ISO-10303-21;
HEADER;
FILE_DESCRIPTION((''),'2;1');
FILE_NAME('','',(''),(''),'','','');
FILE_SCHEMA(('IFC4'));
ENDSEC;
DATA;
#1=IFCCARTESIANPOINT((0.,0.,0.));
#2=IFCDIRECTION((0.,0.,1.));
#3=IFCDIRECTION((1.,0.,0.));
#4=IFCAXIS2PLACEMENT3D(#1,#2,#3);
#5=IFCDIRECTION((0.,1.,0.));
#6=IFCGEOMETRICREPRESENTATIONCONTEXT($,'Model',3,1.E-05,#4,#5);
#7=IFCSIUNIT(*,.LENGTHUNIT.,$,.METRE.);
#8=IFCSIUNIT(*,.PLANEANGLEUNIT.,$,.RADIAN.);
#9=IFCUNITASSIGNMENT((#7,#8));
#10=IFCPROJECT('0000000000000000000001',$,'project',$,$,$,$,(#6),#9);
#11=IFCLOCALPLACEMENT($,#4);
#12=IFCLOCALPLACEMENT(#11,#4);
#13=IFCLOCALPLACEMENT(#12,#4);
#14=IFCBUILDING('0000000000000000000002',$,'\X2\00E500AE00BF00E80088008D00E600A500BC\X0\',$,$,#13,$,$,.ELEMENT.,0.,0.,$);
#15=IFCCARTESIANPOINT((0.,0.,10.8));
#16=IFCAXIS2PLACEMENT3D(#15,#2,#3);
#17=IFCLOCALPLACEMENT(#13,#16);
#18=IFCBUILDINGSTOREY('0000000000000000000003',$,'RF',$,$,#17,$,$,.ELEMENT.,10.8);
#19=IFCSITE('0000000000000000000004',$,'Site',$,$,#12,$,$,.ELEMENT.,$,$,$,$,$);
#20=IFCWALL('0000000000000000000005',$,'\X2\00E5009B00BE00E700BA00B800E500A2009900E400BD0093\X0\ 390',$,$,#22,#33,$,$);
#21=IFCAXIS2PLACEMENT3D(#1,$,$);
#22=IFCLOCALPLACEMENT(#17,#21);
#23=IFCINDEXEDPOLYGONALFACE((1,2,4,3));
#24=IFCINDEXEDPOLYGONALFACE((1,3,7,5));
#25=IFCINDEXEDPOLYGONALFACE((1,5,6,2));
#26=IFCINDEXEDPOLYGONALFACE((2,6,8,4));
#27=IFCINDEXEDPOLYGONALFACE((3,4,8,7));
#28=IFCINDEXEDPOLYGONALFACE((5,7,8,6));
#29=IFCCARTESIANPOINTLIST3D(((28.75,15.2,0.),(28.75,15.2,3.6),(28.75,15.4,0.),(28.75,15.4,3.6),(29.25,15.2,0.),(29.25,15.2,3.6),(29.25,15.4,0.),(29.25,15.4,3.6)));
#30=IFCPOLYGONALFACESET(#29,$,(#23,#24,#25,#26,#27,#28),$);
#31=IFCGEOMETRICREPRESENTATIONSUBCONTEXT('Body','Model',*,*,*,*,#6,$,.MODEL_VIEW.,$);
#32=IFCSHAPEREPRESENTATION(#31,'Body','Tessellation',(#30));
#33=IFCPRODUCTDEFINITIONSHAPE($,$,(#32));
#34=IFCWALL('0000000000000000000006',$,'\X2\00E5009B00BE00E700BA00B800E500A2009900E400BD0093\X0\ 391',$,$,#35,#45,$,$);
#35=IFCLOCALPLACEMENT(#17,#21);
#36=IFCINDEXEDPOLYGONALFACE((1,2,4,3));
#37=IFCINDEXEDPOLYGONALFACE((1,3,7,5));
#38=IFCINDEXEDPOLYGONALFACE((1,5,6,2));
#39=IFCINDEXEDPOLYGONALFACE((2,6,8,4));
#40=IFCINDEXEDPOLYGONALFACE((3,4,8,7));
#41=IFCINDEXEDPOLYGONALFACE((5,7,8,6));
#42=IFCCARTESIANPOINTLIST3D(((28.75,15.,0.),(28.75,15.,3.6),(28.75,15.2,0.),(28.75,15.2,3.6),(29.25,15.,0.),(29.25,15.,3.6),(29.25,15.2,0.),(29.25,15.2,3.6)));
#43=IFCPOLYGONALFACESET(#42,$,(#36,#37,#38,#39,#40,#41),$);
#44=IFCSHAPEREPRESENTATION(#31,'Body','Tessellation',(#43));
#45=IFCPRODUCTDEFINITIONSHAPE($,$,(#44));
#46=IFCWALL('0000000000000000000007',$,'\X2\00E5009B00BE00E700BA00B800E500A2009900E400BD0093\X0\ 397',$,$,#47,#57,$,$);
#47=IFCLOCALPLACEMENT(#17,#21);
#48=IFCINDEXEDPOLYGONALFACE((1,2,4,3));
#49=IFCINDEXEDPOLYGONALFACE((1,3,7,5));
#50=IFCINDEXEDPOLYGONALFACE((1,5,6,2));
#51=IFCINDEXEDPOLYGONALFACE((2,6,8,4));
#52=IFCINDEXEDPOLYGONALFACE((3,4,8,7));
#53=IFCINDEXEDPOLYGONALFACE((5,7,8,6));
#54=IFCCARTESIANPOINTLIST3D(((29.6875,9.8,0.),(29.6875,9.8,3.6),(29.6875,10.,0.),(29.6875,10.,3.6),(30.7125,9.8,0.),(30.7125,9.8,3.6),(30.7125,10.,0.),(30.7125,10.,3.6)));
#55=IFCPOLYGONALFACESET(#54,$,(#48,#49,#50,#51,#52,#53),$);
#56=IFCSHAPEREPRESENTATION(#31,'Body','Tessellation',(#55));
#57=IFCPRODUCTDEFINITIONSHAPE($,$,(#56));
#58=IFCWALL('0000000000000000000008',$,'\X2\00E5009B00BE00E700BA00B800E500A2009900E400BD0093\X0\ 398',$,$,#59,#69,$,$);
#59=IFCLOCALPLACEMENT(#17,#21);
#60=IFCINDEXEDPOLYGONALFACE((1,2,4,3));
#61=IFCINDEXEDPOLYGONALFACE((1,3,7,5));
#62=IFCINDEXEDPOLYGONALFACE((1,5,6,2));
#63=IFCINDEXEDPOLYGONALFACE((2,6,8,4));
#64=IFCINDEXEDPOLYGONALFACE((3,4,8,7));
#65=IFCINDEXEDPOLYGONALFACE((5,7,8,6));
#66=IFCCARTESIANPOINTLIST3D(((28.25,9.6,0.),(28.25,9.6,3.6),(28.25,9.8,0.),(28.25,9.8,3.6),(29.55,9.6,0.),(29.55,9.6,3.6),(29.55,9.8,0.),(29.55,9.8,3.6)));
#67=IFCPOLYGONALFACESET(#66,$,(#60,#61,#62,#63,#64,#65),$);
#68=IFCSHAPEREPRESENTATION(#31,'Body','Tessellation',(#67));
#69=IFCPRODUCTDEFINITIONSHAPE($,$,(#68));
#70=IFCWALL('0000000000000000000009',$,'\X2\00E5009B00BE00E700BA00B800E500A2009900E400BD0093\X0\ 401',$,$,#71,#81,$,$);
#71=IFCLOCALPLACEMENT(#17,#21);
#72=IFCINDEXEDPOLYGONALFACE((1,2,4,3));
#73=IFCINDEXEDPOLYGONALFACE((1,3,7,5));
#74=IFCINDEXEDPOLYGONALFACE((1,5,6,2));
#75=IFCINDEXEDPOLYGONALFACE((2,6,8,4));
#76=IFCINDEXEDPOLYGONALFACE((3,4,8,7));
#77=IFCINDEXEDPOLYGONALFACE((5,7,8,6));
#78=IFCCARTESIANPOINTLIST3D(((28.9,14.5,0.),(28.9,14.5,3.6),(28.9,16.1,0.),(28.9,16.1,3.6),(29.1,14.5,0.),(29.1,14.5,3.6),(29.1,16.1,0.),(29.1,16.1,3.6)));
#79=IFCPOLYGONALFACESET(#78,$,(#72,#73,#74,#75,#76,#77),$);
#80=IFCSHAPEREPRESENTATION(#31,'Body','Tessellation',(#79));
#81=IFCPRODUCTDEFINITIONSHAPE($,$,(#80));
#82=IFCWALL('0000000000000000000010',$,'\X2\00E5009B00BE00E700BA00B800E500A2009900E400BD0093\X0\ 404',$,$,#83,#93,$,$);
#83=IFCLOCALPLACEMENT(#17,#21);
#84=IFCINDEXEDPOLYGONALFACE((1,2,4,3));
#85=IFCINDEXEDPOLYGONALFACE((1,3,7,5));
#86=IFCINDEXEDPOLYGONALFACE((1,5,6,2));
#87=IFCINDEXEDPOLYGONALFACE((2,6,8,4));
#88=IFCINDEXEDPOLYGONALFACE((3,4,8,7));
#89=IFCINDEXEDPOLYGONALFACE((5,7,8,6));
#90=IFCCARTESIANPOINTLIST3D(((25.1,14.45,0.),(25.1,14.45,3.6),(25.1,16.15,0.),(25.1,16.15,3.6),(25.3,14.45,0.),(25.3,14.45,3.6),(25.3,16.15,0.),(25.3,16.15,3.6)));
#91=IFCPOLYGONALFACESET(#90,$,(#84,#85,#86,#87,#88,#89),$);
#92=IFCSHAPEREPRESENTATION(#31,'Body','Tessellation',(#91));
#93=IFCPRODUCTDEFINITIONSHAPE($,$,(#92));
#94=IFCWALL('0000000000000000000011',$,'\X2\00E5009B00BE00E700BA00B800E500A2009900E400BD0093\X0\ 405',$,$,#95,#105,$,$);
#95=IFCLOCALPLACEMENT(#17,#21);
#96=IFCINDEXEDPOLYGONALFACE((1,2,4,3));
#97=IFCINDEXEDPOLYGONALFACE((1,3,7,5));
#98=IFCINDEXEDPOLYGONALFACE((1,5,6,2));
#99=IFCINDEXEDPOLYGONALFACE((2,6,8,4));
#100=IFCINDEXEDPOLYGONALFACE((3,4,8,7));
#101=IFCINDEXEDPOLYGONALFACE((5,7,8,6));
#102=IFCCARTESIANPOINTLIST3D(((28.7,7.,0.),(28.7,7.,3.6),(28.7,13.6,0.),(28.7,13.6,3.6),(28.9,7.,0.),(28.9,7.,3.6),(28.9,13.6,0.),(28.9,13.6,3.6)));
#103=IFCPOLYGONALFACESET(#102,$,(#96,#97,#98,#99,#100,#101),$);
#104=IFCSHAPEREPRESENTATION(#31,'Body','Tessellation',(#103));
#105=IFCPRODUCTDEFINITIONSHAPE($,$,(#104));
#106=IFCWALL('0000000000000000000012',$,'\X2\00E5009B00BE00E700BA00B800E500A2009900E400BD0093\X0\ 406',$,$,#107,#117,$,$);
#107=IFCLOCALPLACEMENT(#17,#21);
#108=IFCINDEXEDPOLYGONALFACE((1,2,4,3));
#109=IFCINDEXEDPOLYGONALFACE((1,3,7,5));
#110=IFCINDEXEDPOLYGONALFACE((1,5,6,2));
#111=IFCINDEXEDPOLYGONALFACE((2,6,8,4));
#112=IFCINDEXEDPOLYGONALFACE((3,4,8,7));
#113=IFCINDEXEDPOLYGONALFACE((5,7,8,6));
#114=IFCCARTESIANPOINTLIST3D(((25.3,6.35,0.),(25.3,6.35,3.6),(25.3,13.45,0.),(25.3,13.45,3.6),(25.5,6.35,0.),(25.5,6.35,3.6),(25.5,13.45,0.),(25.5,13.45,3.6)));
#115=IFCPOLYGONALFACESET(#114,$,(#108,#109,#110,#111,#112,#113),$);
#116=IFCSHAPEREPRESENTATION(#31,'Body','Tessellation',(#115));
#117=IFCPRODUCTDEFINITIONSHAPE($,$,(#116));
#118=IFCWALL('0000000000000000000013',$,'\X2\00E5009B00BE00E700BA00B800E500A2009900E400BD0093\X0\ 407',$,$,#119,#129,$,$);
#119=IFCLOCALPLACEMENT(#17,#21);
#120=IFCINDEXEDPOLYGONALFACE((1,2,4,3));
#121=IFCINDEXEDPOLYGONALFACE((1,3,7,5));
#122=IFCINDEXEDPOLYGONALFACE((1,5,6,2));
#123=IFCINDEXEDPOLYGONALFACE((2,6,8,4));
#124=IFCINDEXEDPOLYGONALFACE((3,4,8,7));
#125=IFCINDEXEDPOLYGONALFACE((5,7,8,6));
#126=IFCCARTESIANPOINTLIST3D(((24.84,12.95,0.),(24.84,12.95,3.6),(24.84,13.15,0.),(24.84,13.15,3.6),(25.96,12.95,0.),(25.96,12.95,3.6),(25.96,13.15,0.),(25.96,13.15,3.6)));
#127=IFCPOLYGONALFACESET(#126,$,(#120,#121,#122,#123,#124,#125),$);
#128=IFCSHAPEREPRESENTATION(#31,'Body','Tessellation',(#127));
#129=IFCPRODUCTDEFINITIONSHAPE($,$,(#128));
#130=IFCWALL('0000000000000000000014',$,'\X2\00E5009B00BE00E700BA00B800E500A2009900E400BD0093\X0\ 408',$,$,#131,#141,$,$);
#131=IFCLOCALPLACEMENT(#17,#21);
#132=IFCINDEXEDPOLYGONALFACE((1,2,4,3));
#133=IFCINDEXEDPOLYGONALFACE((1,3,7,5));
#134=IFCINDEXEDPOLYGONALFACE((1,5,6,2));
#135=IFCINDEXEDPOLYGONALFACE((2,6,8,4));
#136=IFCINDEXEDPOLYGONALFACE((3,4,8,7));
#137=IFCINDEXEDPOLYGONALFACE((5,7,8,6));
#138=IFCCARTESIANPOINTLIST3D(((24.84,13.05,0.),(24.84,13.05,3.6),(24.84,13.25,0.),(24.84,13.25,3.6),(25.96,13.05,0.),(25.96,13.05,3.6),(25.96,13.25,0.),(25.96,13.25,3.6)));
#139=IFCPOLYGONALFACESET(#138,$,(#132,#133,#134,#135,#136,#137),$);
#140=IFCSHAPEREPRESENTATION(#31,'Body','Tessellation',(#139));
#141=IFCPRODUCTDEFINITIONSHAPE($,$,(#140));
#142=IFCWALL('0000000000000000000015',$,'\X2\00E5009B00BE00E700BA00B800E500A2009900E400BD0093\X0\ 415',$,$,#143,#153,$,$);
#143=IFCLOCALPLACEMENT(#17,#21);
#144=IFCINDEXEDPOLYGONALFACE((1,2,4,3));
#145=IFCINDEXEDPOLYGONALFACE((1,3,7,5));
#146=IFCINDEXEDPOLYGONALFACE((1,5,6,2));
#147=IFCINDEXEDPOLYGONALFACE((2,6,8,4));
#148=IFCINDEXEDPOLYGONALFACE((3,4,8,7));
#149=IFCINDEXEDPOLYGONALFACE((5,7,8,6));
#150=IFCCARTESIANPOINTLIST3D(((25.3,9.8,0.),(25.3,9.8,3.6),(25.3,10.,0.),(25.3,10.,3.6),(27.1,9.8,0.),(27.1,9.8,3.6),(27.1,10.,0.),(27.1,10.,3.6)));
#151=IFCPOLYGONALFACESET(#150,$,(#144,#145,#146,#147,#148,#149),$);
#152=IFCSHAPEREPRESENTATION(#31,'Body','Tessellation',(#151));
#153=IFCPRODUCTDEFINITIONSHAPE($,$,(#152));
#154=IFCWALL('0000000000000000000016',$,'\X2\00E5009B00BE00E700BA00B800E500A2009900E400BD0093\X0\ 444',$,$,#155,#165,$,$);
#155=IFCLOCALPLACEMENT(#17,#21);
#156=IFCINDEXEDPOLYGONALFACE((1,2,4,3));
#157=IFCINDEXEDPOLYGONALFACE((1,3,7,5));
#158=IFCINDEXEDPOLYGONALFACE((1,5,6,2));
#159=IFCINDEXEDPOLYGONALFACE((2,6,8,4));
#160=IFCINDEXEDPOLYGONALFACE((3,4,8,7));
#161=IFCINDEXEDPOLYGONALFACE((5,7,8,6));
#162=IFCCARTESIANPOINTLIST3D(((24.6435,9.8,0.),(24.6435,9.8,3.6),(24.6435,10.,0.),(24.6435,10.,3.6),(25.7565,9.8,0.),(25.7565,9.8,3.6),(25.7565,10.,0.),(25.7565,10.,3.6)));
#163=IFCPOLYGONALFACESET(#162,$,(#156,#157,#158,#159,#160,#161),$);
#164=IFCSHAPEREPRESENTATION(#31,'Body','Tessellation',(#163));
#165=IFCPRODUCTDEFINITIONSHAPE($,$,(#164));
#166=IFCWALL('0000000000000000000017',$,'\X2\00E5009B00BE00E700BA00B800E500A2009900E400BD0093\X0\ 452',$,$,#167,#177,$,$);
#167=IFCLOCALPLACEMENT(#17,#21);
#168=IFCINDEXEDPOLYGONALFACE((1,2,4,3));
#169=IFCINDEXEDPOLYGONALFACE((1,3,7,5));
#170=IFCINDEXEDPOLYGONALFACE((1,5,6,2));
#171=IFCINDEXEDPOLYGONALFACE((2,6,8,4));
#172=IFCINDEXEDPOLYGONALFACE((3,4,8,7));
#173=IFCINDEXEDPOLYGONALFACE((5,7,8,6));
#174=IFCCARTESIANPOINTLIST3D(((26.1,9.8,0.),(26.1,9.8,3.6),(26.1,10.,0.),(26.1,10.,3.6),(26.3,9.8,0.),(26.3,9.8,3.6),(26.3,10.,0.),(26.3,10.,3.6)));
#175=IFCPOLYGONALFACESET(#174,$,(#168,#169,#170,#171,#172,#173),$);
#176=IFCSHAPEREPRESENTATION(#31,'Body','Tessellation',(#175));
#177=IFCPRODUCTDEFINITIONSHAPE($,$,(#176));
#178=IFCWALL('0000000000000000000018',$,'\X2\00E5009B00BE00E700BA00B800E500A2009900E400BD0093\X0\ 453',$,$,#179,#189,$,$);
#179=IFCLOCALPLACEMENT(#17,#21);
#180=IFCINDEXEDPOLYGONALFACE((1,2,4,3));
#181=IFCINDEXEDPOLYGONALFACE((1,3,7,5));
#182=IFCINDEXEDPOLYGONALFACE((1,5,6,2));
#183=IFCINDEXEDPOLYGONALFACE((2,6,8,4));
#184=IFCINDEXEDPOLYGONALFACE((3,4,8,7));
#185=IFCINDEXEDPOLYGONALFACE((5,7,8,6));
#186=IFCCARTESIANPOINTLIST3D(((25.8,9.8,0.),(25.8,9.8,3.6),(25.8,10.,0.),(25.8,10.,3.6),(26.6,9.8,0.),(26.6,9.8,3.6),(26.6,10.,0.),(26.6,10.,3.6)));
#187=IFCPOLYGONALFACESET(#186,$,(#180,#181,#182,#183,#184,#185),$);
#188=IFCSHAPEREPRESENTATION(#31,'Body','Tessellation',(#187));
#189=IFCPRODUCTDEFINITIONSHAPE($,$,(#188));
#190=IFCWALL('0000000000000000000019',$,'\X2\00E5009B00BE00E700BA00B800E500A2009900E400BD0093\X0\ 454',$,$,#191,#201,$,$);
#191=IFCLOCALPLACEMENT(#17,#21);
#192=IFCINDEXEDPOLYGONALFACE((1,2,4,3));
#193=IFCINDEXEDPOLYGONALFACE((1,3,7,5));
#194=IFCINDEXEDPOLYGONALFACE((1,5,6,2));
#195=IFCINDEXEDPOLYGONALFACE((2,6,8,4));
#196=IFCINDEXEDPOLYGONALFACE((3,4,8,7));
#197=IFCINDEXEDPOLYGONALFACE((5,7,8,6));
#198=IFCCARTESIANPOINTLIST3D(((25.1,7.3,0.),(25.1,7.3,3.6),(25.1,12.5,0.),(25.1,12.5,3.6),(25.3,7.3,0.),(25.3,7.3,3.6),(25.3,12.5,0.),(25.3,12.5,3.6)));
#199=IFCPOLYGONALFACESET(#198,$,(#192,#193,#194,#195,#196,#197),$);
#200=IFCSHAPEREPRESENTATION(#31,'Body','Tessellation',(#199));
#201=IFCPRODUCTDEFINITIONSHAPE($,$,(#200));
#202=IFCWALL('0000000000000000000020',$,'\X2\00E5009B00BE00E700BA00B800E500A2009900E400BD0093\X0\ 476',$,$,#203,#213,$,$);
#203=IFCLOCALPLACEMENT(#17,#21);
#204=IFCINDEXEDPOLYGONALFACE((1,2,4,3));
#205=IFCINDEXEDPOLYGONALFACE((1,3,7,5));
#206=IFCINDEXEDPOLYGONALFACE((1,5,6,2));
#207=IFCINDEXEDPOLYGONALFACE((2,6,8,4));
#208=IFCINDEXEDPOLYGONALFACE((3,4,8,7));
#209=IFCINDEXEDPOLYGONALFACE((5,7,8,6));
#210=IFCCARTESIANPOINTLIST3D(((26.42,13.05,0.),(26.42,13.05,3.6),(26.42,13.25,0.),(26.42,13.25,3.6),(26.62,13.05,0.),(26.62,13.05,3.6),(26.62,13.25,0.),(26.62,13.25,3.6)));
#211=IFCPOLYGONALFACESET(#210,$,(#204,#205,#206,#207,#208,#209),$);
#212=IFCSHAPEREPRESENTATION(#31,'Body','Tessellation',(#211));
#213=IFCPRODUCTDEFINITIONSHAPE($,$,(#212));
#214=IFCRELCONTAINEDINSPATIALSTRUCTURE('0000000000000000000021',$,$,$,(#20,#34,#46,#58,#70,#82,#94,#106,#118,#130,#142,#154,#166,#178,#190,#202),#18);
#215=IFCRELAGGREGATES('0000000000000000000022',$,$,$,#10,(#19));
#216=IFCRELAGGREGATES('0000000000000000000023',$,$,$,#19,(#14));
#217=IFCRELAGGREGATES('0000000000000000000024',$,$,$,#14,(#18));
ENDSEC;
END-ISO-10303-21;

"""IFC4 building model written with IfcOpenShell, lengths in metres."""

from ifc_helpers import new_model, si_unit, direction, frame, frame_2d, origin_with_axes, place, context, subcontext, project, spatial, rectangle, extrude, element, save


model = new_model("IFC4")

# Units and contexts
model_context = context("Model", 3, precision=1e-05, world=origin_with_axes(), true_north=direction((0.0, 1.0, 0.0)))
body_context = subcontext(model_context, "Body", "Model", "MODEL_VIEW")
ifc_project = project(units=[si_unit("LENGTHUNIT", "METRE"), si_unit("PLANEANGLEUNIT", "RADIAN")], contexts=[model_context])

# Site, building, storey
placement = place(None, origin_with_axes())
site_placement = place(placement, origin_with_axes())
site = spatial("IfcSite", under=ifc_project, at=site_placement, Name="Site", CompositionType="ELEMENT")
building_placement = place(site_placement, origin_with_axes())
building = spatial("IfcBuilding", under=site, at=building_placement, Name="å®¿è\u0088\u008dæ¥¼", CompositionType="ELEMENT", ElevationOfRefHeight=0.0, ElevationOfTerrain=0.0)
storey_placement = place(building_placement, frame((0.0, 0.0, 10.8), z_axis=(0.0, 0.0, 1.0), x_axis=(1.0, 0.0, 0.0)))
storey = spatial("IfcBuildingStorey", under=building, at=storey_placement, Name="RF", CompositionType="ELEMENT", Elevation=10.8)

# Walls
for number, where, z_axis, x_axis, name in (
    (1, (29.0, 15.3, 0.0), (0.0, 0.0, 1.0), (1.0, 0.0, 0.0), "å\u009b¾çº¸å¢\u0099ä½\u0093 390"),
    (2, (29.0, 15.1, 0.0), (0.0, 0.0, 1.0), (1.0, 0.0, 0.0), "å\u009b¾çº¸å¢\u0099ä½\u0093 391"),
):
    element("IfcWall", number, at=place(storey_placement, frame(where, z_axis=z_axis, x_axis=x_axis)), inside=storey, Name=name, context=body_context, shape_type="SweptSolid", body=[
        extrude(rectangle(XDim=0.5, YDim=0.2, at=frame_2d((0.0, 0.0), x_axis=(1.0, 0.0, 0.0))), frame((0.0, 0.0, 0.0), z_axis=(0.0, 0.0, 1.0)), (0.0, 0.0, 1.0), 3.6),
    ])
wall_1_placement = place(storey_placement, frame((30.2, 9.9, 0.0), z_axis=(0.0, 0.0, 1.0), x_axis=(-1.0, 0.0, 0.0)))
element("IfcWall", 3, at=wall_1_placement, inside=storey, Name="å\u009b¾çº¸å¢\u0099ä½\u0093 397", context=body_context, shape_type="SweptSolid", body=[
    extrude(rectangle(XDim=1.025, YDim=0.2, at=frame_2d((0.0, 0.0), x_axis=(1.0, 0.0, 0.0))), frame((0.0, 0.0, 0.0), z_axis=(0.0, 0.0, 1.0)), (0.0, 0.0, 1.0), 3.6),
])
wall_2_placement = place(storey_placement, frame((28.9, 9.7, 0.0), z_axis=(0.0, 0.0, 1.0), x_axis=(1.0, 0.0, 0.0)))
element("IfcWall", 4, at=wall_2_placement, inside=storey, Name="å\u009b¾çº¸å¢\u0099ä½\u0093 398", context=body_context, shape_type="SweptSolid", body=[
    extrude(rectangle(XDim=1.3, YDim=0.2, at=frame_2d((0.0, 0.0), x_axis=(1.0, 0.0, 0.0))), frame((0.0, 0.0, 0.0), z_axis=(0.0, 0.0, 1.0)), (0.0, 0.0, 1.0), 3.6),
])
wall_3_placement = place(storey_placement, frame((29.0, 15.3, 0.0), z_axis=(0.0, 0.0, 1.0), x_axis=(0.0, 1.0, 0.0)))
element("IfcWall", 5, at=wall_3_placement, inside=storey, Name="å\u009b¾çº¸å¢\u0099ä½\u0093 401", context=body_context, shape_type="SweptSolid", body=[
    extrude(rectangle(XDim=1.6, YDim=0.2, at=frame_2d((0.0, 0.0), x_axis=(1.0, 0.0, 0.0))), frame((0.0, 0.0, 0.0), z_axis=(0.0, 0.0, 1.0)), (0.0, 0.0, 1.0), 3.6),
])
wall_4_placement = place(storey_placement, frame((25.2, 15.3, 0.0), z_axis=(0.0, 0.0, 1.0), x_axis=(0.0, 1.0, 0.0)))
element("IfcWall", 6, at=wall_4_placement, inside=storey, Name="å\u009b¾çº¸å¢\u0099ä½\u0093 404", context=body_context, shape_type="SweptSolid", body=[
    extrude(rectangle(XDim=1.7, YDim=0.2, at=frame_2d((0.0, 0.0), x_axis=(1.0, 0.0, 0.0))), frame((0.0, 0.0, 0.0), z_axis=(0.0, 0.0, 1.0)), (0.0, 0.0, 1.0), 3.6),
])
wall_5_placement = place(storey_placement, frame((28.8, 10.3, 0.0), z_axis=(0.0, 0.0, 1.0), x_axis=(0.0, 1.0, 0.0)))
element("IfcWall", 7, at=wall_5_placement, inside=storey, Name="å\u009b¾çº¸å¢\u0099ä½\u0093 405", context=body_context, shape_type="SweptSolid", body=[
    extrude(rectangle(XDim=6.6, YDim=0.2, at=frame_2d((0.0, 0.0), x_axis=(1.0, 0.0, 0.0))), frame((0.0, 0.0, 0.0), z_axis=(0.0, 0.0, 1.0)), (0.0, 0.0, 1.0), 3.6),
])
wall_6_placement = place(storey_placement, frame((25.4, 9.9, 0.0), z_axis=(0.0, 0.0, 1.0), x_axis=(0.0, 1.0, 0.0)))
element("IfcWall", 8, at=wall_6_placement, inside=storey, Name="å\u009b¾çº¸å¢\u0099ä½\u0093 406", context=body_context, shape_type="SweptSolid", body=[
    extrude(rectangle(XDim=7.1, YDim=0.2, at=frame_2d((0.0, 0.0), x_axis=(1.0, 0.0, 0.0))), frame((0.0, 0.0, 0.0), z_axis=(0.0, 0.0, 1.0)), (0.0, 0.0, 1.0), 3.6),
])
for number, where, z_axis, x_axis, name in (
    (9, (25.4, 13.05, 0.0), (0.0, 0.0, 1.0), (1.0, 0.0, 0.0), "å\u009b¾çº¸å¢\u0099ä½\u0093 407"),
    (10, (25.4, 13.15, 0.0), (0.0, 0.0, 1.0), (1.0, 0.0, 0.0), "å\u009b¾çº¸å¢\u0099ä½\u0093 408"),
):
    element("IfcWall", number, at=place(storey_placement, frame(where, z_axis=z_axis, x_axis=x_axis)), inside=storey, Name=name, context=body_context, shape_type="SweptSolid", body=[
        extrude(rectangle(XDim=1.12, YDim=0.2, at=frame_2d((0.0, 0.0), x_axis=(1.0, 0.0, 0.0))), frame((0.0, 0.0, 0.0), z_axis=(0.0, 0.0, 1.0)), (0.0, 0.0, 1.0), 3.6),
    ])
wall_7_placement = place(storey_placement, frame((26.2, 9.9, 0.0), z_axis=(0.0, 0.0, 1.0), x_axis=(1.0, 0.0, 0.0)))
element("IfcWall", 11, at=wall_7_placement, inside=storey, Name="å\u009b¾çº¸å¢\u0099ä½\u0093 415", context=body_context, shape_type="SweptSolid", body=[
    extrude(rectangle(XDim=1.8, YDim=0.2, at=frame_2d((0.0, 0.0), x_axis=(1.0, 0.0, 0.0))), frame((0.0, 0.0, 0.0), z_axis=(0.0, 0.0, 1.0)), (0.0, 0.0, 1.0), 3.6),
])
wall_8_placement = place(storey_placement, frame((25.2, 9.9, 0.0), z_axis=(0.0, 0.0, 1.0), x_axis=(-1.0, 0.0, 0.0)))
element("IfcWall", 12, at=wall_8_placement, inside=storey, Name="å\u009b¾çº¸å¢\u0099ä½\u0093 444", context=body_context, shape_type="SweptSolid", body=[
    extrude(rectangle(XDim=1.113, YDim=0.2, at=frame_2d((0.0, 0.0), x_axis=(1.0, 0.0, 0.0))), frame((0.0, 0.0, 0.0), z_axis=(0.0, 0.0, 1.0)), (0.0, 0.0, 1.0), 3.6),
])
wall_9_placement = place(storey_placement, frame((26.2, 9.9, 0.0), z_axis=(0.0, 0.0, 1.0), x_axis=(0.0, -1.0, 0.0)))
element("IfcWall", 13, at=wall_9_placement, inside=storey, Name="å\u009b¾çº¸å¢\u0099ä½\u0093 452", context=body_context, shape_type="SweptSolid", body=[
    extrude(rectangle(XDim=0.2, YDim=0.2, at=frame_2d((0.0, 0.0), x_axis=(1.0, 0.0, 0.0))), frame((0.0, 0.0, 0.0), z_axis=(0.0, 0.0, 1.0)), (0.0, 0.0, 1.0), 3.6),
])
wall_10_placement = place(storey_placement, frame((26.2, 9.9, 0.0), z_axis=(0.0, 0.0, 1.0), x_axis=(-1.0, 0.0, 0.0)))
element("IfcWall", 14, at=wall_10_placement, inside=storey, Name="å\u009b¾çº¸å¢\u0099ä½\u0093 453", context=body_context, shape_type="SweptSolid", body=[
    extrude(rectangle(XDim=0.8, YDim=0.2, at=frame_2d((0.0, 0.0), x_axis=(1.0, 0.0, 0.0))), frame((0.0, 0.0, 0.0), z_axis=(0.0, 0.0, 1.0)), (0.0, 0.0, 1.0), 3.6),
])
wall_11_placement = place(storey_placement, frame((25.2, 9.9, 0.0), z_axis=(0.0, 0.0, 1.0), x_axis=(0.0, 1.0, 0.0)))
element("IfcWall", 15, at=wall_11_placement, inside=storey, Name="å\u009b¾çº¸å¢\u0099ä½\u0093 454", context=body_context, shape_type="SweptSolid", body=[
    extrude(rectangle(XDim=5.2, YDim=0.2, at=frame_2d((0.0, 0.0), x_axis=(1.0, 0.0, 0.0))), frame((0.0, 0.0, 0.0), z_axis=(0.0, 0.0, 1.0)), (0.0, 0.0, 1.0), 3.6),
])
for number, where, z_axis, x_axis, name in (
    (16, (26.52, 13.15, 0.0), (0.0, 0.0, 1.0), (0.0, -1.0, 0.0), "å\u009b¾çº¸å¢\u0099ä½\u0093 476"),
):
    element("IfcWall", number, at=place(storey_placement, frame(where, z_axis=z_axis, x_axis=x_axis)), inside=storey, Name=name, context=body_context, shape_type="SweptSolid", body=[
        extrude(rectangle(XDim=0.2, YDim=0.2, at=frame_2d((0.0, 0.0), x_axis=(1.0, 0.0, 0.0))), frame((0.0, 0.0, 0.0), z_axis=(0.0, 0.0, 1.0)), (0.0, 0.0, 1.0), 3.6),
    ])

save(model, "model.ifc")
